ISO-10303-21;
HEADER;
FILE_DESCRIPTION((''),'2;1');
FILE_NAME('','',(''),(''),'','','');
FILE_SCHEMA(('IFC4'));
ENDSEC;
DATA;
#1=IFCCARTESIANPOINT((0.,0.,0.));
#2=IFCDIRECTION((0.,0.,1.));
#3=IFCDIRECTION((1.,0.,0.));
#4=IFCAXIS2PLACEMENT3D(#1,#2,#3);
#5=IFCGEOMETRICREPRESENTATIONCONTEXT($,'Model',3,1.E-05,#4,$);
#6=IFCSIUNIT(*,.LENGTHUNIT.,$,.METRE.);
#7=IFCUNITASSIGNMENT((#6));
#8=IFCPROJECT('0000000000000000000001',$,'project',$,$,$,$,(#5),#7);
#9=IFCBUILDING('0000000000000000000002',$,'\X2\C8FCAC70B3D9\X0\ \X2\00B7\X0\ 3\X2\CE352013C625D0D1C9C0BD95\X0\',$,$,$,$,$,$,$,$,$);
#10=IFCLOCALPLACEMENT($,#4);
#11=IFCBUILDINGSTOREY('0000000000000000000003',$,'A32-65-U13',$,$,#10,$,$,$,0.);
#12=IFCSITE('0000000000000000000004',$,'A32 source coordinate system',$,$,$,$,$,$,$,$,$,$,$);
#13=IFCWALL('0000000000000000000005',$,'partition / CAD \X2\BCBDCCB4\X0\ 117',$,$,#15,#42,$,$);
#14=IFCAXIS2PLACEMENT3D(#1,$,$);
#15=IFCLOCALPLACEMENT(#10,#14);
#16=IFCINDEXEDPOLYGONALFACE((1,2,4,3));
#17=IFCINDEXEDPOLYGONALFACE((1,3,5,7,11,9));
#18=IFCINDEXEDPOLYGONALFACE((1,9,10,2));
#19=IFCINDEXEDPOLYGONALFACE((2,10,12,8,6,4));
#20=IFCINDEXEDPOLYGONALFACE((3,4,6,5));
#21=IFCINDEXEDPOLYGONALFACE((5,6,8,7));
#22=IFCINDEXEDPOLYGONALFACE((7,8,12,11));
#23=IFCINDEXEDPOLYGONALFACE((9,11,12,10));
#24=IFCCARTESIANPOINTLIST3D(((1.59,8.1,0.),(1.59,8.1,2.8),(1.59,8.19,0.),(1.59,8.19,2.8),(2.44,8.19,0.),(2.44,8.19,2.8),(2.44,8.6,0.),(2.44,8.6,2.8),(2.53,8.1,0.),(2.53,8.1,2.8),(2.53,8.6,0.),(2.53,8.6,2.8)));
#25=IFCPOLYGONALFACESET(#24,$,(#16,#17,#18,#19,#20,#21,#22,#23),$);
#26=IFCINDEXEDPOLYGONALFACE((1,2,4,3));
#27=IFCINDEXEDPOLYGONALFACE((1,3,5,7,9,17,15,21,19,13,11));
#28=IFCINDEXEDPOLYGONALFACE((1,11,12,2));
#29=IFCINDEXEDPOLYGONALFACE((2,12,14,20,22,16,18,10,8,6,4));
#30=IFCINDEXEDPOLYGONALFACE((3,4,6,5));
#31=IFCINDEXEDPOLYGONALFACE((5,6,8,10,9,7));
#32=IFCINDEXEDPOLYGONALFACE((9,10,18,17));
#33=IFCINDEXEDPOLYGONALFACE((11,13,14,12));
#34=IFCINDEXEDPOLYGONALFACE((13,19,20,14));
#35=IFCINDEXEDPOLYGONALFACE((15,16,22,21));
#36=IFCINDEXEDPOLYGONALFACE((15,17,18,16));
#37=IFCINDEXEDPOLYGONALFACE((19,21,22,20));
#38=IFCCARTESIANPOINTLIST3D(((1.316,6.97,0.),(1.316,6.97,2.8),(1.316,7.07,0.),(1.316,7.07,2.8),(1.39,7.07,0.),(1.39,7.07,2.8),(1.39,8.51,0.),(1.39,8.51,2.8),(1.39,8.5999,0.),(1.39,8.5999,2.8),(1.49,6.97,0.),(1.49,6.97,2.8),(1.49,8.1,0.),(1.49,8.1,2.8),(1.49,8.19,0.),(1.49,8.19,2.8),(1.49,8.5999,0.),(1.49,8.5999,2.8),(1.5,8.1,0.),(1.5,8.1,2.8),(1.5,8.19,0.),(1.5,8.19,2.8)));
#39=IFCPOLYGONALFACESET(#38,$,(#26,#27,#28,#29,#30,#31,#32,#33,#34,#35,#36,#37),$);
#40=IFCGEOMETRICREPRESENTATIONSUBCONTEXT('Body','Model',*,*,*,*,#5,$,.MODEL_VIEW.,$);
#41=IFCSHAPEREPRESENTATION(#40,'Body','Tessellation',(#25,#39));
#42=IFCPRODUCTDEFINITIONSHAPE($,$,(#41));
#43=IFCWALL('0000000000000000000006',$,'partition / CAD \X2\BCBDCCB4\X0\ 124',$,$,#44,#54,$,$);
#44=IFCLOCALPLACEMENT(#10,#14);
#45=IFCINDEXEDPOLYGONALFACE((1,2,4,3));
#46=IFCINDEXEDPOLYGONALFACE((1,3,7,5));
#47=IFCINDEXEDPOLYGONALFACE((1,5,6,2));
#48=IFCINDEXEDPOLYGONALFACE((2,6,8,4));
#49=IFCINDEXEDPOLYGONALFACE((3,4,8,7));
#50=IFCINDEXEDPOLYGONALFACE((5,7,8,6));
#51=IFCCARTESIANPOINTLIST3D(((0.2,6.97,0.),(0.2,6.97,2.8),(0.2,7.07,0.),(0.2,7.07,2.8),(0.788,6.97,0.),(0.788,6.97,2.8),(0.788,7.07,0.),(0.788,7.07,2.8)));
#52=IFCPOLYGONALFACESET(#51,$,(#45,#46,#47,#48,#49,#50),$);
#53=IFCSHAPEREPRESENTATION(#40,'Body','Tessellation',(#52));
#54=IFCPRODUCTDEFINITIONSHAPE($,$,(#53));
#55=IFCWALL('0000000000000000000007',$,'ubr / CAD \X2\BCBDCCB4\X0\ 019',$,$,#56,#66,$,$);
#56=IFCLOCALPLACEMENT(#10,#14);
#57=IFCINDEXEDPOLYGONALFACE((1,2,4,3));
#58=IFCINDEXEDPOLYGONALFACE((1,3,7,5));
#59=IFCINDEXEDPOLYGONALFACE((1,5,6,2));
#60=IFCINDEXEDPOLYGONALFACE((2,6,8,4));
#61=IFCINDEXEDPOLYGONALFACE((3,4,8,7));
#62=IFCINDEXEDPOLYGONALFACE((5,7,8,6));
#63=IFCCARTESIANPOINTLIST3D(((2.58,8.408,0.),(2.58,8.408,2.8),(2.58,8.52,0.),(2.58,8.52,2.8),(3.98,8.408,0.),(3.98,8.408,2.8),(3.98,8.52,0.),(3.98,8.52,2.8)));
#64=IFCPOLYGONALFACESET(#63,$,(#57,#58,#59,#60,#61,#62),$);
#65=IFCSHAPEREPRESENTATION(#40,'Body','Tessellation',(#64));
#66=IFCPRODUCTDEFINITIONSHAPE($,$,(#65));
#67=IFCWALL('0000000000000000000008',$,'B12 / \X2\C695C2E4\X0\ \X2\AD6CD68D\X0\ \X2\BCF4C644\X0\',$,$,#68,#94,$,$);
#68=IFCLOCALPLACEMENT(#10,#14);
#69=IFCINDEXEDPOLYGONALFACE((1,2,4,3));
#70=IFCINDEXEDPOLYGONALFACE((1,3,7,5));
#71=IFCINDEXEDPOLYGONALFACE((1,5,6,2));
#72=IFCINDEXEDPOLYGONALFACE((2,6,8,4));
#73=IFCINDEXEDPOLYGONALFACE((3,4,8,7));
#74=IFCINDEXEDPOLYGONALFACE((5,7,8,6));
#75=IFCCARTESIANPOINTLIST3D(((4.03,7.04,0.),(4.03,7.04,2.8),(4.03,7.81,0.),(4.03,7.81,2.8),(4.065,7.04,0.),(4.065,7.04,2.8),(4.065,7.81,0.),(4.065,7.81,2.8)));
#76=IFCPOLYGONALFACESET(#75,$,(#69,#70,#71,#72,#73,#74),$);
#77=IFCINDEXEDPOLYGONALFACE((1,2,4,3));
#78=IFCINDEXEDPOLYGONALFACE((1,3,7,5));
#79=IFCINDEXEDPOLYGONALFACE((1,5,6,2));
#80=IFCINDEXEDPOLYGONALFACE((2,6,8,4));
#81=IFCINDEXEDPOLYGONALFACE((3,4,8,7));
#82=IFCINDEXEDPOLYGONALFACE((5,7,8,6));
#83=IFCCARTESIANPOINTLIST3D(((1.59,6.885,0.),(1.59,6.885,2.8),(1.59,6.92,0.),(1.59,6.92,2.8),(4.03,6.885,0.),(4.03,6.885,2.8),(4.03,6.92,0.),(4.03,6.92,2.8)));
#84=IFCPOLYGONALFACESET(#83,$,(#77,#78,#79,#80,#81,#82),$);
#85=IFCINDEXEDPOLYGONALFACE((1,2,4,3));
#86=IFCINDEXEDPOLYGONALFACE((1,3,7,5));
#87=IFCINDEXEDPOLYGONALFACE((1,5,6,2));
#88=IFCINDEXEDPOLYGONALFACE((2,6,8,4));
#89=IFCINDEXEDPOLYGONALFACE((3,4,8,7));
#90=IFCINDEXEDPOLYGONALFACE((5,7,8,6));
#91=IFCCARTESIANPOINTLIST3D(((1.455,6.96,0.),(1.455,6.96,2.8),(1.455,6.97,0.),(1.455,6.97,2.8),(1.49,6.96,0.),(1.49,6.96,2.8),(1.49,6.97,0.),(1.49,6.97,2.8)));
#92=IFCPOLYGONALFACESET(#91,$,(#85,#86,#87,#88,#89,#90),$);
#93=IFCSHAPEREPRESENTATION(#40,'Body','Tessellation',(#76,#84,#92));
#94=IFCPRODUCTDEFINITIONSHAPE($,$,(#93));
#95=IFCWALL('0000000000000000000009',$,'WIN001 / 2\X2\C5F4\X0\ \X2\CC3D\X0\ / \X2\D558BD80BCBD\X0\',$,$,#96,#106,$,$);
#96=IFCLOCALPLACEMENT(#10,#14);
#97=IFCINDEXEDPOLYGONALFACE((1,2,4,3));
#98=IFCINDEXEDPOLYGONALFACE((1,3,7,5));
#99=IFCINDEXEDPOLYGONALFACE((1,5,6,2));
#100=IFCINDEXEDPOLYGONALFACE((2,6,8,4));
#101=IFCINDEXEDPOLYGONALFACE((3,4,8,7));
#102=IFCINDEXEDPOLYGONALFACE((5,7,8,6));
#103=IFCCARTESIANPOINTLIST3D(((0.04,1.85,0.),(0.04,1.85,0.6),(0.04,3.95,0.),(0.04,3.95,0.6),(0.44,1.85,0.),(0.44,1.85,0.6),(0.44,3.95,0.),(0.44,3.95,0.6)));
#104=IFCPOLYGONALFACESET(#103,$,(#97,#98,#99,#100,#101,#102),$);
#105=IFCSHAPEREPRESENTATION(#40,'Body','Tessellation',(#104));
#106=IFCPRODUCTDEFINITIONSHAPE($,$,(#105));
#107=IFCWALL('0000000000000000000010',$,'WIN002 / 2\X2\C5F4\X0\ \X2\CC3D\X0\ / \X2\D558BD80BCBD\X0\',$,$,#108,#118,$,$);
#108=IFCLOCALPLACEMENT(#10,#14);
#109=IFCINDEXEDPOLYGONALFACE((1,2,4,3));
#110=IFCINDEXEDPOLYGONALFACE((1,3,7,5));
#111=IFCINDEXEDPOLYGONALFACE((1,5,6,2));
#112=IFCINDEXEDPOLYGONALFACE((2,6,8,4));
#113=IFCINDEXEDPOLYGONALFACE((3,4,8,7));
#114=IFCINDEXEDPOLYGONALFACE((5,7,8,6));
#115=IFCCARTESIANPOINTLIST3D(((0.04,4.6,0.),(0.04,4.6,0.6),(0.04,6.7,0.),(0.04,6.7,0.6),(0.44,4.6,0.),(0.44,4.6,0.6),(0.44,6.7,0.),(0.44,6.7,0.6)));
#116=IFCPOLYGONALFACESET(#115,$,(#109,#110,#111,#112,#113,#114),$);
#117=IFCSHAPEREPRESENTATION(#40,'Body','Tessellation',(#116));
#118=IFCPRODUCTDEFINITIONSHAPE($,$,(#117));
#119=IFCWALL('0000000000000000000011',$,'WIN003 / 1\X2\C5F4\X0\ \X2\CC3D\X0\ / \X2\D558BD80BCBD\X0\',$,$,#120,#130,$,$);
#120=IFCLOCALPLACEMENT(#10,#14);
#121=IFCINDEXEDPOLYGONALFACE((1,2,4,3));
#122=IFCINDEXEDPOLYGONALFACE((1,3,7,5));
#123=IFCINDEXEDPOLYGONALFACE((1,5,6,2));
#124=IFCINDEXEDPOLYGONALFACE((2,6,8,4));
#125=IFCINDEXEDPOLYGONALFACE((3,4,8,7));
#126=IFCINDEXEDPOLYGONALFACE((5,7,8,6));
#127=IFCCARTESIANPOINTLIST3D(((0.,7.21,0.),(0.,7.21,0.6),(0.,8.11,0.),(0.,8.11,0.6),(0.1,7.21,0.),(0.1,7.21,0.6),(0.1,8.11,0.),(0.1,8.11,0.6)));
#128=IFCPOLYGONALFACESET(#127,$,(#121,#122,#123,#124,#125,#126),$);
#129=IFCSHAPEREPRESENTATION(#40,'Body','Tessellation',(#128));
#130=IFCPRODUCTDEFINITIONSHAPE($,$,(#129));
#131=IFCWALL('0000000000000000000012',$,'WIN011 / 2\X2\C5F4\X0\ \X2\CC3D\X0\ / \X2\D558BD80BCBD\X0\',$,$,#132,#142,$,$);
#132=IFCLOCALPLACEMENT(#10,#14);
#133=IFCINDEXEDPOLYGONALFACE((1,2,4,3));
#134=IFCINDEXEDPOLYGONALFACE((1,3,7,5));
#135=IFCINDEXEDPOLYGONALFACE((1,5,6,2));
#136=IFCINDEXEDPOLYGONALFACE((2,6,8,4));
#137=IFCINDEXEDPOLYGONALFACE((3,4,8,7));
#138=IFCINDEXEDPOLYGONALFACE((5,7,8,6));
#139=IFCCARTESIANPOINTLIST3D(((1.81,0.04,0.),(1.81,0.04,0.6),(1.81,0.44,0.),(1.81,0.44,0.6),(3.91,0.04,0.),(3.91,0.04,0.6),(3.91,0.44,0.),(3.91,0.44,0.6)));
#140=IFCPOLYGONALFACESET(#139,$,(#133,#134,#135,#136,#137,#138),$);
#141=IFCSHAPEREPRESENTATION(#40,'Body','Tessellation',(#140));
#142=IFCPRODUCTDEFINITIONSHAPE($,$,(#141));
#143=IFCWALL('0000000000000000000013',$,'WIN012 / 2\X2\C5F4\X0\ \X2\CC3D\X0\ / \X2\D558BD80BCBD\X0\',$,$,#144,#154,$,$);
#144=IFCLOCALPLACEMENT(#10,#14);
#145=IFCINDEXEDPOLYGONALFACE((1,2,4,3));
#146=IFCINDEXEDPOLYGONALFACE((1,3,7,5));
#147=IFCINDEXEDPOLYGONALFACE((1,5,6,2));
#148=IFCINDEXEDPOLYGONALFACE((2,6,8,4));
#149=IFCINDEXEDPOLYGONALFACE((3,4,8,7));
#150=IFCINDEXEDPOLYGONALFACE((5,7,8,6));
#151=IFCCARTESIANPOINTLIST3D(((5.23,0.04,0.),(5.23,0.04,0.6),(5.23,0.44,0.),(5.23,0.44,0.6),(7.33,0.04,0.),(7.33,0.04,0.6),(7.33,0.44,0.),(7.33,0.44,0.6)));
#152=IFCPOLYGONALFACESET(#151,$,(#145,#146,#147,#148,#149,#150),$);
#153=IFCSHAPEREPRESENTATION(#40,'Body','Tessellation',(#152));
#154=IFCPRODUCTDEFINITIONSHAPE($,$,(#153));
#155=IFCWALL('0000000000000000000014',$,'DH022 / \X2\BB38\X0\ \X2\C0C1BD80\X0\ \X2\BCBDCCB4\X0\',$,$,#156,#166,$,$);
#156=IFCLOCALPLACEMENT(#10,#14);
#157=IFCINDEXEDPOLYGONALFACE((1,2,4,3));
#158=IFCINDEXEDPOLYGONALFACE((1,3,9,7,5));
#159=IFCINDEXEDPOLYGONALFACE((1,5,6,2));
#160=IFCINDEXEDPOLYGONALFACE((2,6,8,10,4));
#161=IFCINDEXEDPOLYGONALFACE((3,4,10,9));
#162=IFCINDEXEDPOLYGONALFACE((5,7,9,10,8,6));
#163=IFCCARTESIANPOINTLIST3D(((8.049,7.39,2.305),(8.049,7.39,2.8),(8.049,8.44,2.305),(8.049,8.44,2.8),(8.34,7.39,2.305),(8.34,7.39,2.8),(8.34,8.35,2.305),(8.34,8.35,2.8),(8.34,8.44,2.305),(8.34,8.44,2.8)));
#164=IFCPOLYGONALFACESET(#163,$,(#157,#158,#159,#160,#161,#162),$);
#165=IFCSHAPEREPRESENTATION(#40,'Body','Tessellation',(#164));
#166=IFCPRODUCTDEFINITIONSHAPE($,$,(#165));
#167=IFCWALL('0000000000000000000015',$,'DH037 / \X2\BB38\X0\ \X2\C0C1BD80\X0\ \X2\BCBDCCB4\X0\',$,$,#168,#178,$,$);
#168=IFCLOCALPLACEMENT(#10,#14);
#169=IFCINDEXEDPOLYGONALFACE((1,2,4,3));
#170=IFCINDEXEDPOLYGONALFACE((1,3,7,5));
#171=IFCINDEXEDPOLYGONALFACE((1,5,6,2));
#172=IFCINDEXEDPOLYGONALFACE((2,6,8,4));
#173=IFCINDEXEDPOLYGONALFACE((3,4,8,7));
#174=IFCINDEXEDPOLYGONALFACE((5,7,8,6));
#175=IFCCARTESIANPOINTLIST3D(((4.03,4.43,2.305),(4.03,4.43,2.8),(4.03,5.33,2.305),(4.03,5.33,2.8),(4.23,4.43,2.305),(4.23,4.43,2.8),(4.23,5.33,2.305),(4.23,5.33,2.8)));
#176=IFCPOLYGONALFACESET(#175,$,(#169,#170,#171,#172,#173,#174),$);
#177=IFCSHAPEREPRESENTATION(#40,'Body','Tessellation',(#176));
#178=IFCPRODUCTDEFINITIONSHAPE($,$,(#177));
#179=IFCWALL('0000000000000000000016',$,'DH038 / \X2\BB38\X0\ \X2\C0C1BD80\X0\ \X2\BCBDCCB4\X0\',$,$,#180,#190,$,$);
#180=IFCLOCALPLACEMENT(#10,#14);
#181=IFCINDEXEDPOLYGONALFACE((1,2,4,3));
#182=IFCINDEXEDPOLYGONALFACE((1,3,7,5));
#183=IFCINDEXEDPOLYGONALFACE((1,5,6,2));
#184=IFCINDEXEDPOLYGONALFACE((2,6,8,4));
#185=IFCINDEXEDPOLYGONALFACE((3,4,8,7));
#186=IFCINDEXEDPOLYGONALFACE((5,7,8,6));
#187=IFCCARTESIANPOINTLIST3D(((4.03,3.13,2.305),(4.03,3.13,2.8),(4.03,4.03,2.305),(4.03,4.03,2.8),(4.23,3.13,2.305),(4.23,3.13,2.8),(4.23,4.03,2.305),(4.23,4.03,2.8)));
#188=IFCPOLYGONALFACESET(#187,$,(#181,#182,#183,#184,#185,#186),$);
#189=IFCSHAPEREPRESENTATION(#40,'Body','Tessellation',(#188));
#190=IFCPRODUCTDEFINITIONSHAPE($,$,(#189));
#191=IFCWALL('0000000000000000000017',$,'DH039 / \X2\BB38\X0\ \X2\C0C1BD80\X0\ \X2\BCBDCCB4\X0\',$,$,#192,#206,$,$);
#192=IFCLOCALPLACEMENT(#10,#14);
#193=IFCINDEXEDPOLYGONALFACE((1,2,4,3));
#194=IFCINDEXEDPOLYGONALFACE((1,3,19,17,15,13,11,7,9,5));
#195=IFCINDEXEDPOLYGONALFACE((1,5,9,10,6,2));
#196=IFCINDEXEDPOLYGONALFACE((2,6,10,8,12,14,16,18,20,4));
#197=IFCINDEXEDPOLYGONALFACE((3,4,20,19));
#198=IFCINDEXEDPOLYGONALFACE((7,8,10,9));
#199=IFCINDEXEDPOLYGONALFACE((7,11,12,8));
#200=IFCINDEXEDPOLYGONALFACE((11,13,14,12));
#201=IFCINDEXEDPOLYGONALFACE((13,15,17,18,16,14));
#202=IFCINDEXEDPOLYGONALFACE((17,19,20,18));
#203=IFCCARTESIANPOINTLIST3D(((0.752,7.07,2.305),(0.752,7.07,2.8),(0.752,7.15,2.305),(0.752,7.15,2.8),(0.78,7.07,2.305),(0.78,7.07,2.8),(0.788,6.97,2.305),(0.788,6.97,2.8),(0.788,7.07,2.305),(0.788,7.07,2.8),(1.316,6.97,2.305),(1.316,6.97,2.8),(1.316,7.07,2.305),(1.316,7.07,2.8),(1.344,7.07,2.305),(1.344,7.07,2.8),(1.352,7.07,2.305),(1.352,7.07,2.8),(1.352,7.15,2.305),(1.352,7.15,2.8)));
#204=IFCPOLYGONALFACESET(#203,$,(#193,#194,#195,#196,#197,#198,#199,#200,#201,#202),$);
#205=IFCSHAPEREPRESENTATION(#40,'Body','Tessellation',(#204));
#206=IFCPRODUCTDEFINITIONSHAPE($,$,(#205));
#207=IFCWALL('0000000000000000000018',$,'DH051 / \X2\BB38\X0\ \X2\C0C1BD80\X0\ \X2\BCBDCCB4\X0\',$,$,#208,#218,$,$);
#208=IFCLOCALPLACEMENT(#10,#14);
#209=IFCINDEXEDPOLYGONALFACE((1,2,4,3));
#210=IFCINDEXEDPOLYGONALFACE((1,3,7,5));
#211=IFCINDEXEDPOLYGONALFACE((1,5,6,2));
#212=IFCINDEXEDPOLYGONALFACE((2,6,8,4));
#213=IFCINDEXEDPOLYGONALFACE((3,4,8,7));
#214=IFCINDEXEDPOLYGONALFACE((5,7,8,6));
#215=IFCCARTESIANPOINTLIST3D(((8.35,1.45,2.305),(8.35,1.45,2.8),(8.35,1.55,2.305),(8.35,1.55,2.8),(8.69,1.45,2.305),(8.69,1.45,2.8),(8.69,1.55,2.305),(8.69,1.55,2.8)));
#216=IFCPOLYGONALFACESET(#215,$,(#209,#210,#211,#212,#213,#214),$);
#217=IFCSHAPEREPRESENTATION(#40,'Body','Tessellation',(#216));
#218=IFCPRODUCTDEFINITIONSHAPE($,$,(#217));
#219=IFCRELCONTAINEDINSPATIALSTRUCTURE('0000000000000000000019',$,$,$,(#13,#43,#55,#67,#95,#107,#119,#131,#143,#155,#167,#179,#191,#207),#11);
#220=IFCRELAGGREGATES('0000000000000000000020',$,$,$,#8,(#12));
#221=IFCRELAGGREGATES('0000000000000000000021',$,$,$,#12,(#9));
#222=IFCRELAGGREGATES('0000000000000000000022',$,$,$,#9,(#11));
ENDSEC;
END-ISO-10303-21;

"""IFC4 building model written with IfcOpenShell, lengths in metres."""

from ifc_helpers import new_model, si_unit, frame, origin, origin_with_axes, place, context, subcontext, project, spatial, polyline, outline, extrude, element, save


model = new_model("IFC4")

# Units and contexts
model_context = context("Model", 3, precision=1e-05, world=origin_with_axes())
body_context = subcontext(model_context, "Body", "Model", "MODEL_VIEW")
ifc_project = project(units=[si_unit("LENGTHUNIT", "METRE")], contexts=[model_context])

# Site, building, storey
site = spatial("IfcSite", under=ifc_project, Name="A32 source coordinate system")
building = spatial("IfcBuilding", under=site, Name="주거동 · 3층–옥탑지붕")
storey_placement = place(None, origin_with_axes())
storey = spatial("IfcBuildingStorey", under=building, at=storey_placement, Name="A32-65-U13", Elevation=0.0)

# Walls
wall_1_placement = place(storey_placement, origin_with_axes())
element("IfcWall", 1, at=wall_1_placement, inside=storey, Name="partition / CAD 벽체 117", context=body_context, shape_type="SweptSolid", body=[
    extrude(outline(polyline([(2.53, 8.1), (1.59, 8.1), (1.59, 8.19), (2.44, 8.19), (2.44, 8.6), (2.53, 8.6), (2.53, 8.1)])), origin(), (0.0, 0.0, 1.0), 2.8),
    extrude(outline(polyline([(1.49, 8.1), (1.49, 6.97), (1.316, 6.97), (1.316, 7.07), (1.39, 7.07), (1.39, 8.51), (1.39, 8.5999), (1.49, 8.5999), (1.49, 8.19), (1.5, 8.19), (1.5, 8.1), (1.49, 8.1)])), origin(), (0.0, 0.0, 1.0), 2.8),
])
wall_2_placement = place(storey_placement, origin_with_axes())
element("IfcWall", 2, at=wall_2_placement, inside=storey, Name="partition / CAD 벽체 124", context=body_context, shape_type="SweptSolid", body=[
    extrude(outline(polyline([(0.788, 7.07), (0.788, 6.97), (0.2, 6.97), (0.2, 7.07), (0.788, 7.07)])), origin(), (0.0, 0.0, 1.0), 2.8),
])
wall_3_placement = place(storey_placement, origin_with_axes())
element("IfcWall", 3, at=wall_3_placement, inside=storey, Name="ubr / CAD 벽체 019", context=body_context, shape_type="SweptSolid", body=[
    extrude(outline(polyline([(3.98, 8.408), (2.58, 8.408), (2.58, 8.52), (3.98, 8.52), (3.98, 8.408)])), origin(), (0.0, 0.0, 1.0), 2.8),
])
wall_4_placement = place(storey_placement, origin_with_axes())
element("IfcWall", 4, at=wall_4_placement, inside=storey, Name="B12 / 욕실 구획 보완", context=body_context, shape_type="SweptSolid", body=[
    extrude(outline(polyline([(4.065, 7.04), (4.03, 7.04), (4.03, 7.81), (4.065, 7.81), (4.065, 7.04)])), origin(), (0.0, 0.0, 1.0), 2.8),
    extrude(outline(polyline([(1.59, 6.92), (4.03, 6.92), (4.03, 6.885), (1.59, 6.885), (1.59, 6.92)])), origin(), (0.0, 0.0, 1.0), 2.8),
    extrude(outline(polyline([(1.455, 6.97), (1.49, 6.97), (1.49, 6.96), (1.455, 6.96), (1.455, 6.97)])), origin(), (0.0, 0.0, 1.0), 2.8),
])
wall_5_placement = place(storey_placement, origin_with_axes())
element("IfcWall", 5, at=wall_5_placement, inside=storey, Name="WIN001 / 2열 창 / 하부벽", context=body_context, shape_type="SweptSolid", body=[
    extrude(outline(polyline([(0.04, 3.95), (0.44, 3.95), (0.44, 1.85), (0.04, 1.85), (0.04, 3.95)])), origin(), (0.0, 0.0, 1.0), 0.6),
])
wall_6_placement = place(storey_placement, origin_with_axes())
element("IfcWall", 6, at=wall_6_placement, inside=storey, Name="WIN002 / 2열 창 / 하부벽", context=body_context, shape_type="SweptSolid", body=[
    extrude(outline(polyline([(0.04, 6.7), (0.44, 6.7), (0.44, 4.6), (0.04, 4.6), (0.04, 6.7)])), origin(), (0.0, 0.0, 1.0), 0.6),
])
wall_7_placement = place(storey_placement, origin_with_axes())
element("IfcWall", 7, at=wall_7_placement, inside=storey, Name="WIN003 / 1열 창 / 하부벽", context=body_context, shape_type="SweptSolid", body=[
    extrude(outline(polyline([(0.0, 8.11), (0.1, 8.11), (0.1, 7.21), (0.0, 7.21), (0.0, 8.11)])), origin(), (0.0, 0.0, 1.0), 0.6),
])
wall_8_placement = place(storey_placement, origin_with_axes())
element("IfcWall", 8, at=wall_8_placement, inside=storey, Name="WIN011 / 2열 창 / 하부벽", context=body_context, shape_type="SweptSolid", body=[
    extrude(outline(polyline([(1.81, 0.44), (3.91, 0.44), (3.91, 0.04), (1.81, 0.04), (1.81, 0.44)])), origin(), (0.0, 0.0, 1.0), 0.6),
])
wall_9_placement = place(storey_placement, origin_with_axes())
element("IfcWall", 9, at=wall_9_placement, inside=storey, Name="WIN012 / 2열 창 / 하부벽", context=body_context, shape_type="SweptSolid", body=[
    extrude(outline(polyline([(5.23, 0.44), (7.33, 0.44), (7.33, 0.04), (5.23, 0.04), (5.23, 0.44)])), origin(), (0.0, 0.0, 1.0), 0.6),
])
wall_10_placement = place(storey_placement, origin_with_axes())
element("IfcWall", 10, at=wall_10_placement, inside=storey, Name="DH022 / 문 상부 벽체", context=body_context, shape_type="SweptSolid", body=[
    extrude(outline(polyline([(8.049, 7.39), (8.049, 8.44), (8.34, 8.44), (8.34, 8.35), (8.34, 8.35), (8.34, 7.39), (8.049, 7.39)])), frame((0.0, 0.0, 2.305)), (0.0, 0.0, 1.0), 0.495),
])
wall_11_placement = place(storey_placement, origin_with_axes())
element("IfcWall", 11, at=wall_11_placement, inside=storey, Name="DH037 / 문 상부 벽체", context=body_context, shape_type="SweptSolid", body=[
    extrude(outline(polyline([(4.23, 5.33), (4.23, 4.43), (4.03, 4.43), (4.03, 5.33), (4.23, 5.33)])), frame((0.0, 0.0, 2.305)), (0.0, 0.0, 1.0), 0.495),
])
wall_12_placement = place(storey_placement, origin_with_axes())
element("IfcWall", 12, at=wall_12_placement, inside=storey, Name="DH038 / 문 상부 벽체", context=body_context, shape_type="SweptSolid", body=[
    extrude(outline(polyline([(4.23, 4.03), (4.23, 3.13), (4.03, 3.13), (4.03, 4.03), (4.23, 4.03)])), frame((0.0, 0.0, 2.305)), (0.0, 0.0, 1.0), 0.495),
])
wall_13_placement = place(storey_placement, origin_with_axes())
element("IfcWall", 13, at=wall_13_placement, inside=storey, Name="DH039 / 문 상부 벽체", context=body_context, shape_type="SweptSolid", body=[
    extrude(outline(polyline([(1.316, 7.07), (1.316, 6.97), (0.788, 6.97), (0.788, 7.07), (0.78, 7.07), (0.752, 7.07), (0.752, 7.15), (1.352, 7.15), (1.352, 7.07), (1.344, 7.07), (1.316, 7.07)])), frame((0.0, 0.0, 2.305)), (0.0, 0.0, 1.0), 0.495),
])
wall_14_placement = place(storey_placement, origin_with_axes())
element("IfcWall", 14, at=wall_14_placement, inside=storey, Name="DH051 / 문 상부 벽체", context=body_context, shape_type="SweptSolid", body=[
    extrude(outline(polyline([(8.69, 1.55), (8.69, 1.45), (8.35, 1.45), (8.35, 1.55), (8.69, 1.55)])), frame((0.0, 0.0, 2.305)), (0.0, 0.0, 1.0), 0.495),
])

save(model, "model.ifc")
